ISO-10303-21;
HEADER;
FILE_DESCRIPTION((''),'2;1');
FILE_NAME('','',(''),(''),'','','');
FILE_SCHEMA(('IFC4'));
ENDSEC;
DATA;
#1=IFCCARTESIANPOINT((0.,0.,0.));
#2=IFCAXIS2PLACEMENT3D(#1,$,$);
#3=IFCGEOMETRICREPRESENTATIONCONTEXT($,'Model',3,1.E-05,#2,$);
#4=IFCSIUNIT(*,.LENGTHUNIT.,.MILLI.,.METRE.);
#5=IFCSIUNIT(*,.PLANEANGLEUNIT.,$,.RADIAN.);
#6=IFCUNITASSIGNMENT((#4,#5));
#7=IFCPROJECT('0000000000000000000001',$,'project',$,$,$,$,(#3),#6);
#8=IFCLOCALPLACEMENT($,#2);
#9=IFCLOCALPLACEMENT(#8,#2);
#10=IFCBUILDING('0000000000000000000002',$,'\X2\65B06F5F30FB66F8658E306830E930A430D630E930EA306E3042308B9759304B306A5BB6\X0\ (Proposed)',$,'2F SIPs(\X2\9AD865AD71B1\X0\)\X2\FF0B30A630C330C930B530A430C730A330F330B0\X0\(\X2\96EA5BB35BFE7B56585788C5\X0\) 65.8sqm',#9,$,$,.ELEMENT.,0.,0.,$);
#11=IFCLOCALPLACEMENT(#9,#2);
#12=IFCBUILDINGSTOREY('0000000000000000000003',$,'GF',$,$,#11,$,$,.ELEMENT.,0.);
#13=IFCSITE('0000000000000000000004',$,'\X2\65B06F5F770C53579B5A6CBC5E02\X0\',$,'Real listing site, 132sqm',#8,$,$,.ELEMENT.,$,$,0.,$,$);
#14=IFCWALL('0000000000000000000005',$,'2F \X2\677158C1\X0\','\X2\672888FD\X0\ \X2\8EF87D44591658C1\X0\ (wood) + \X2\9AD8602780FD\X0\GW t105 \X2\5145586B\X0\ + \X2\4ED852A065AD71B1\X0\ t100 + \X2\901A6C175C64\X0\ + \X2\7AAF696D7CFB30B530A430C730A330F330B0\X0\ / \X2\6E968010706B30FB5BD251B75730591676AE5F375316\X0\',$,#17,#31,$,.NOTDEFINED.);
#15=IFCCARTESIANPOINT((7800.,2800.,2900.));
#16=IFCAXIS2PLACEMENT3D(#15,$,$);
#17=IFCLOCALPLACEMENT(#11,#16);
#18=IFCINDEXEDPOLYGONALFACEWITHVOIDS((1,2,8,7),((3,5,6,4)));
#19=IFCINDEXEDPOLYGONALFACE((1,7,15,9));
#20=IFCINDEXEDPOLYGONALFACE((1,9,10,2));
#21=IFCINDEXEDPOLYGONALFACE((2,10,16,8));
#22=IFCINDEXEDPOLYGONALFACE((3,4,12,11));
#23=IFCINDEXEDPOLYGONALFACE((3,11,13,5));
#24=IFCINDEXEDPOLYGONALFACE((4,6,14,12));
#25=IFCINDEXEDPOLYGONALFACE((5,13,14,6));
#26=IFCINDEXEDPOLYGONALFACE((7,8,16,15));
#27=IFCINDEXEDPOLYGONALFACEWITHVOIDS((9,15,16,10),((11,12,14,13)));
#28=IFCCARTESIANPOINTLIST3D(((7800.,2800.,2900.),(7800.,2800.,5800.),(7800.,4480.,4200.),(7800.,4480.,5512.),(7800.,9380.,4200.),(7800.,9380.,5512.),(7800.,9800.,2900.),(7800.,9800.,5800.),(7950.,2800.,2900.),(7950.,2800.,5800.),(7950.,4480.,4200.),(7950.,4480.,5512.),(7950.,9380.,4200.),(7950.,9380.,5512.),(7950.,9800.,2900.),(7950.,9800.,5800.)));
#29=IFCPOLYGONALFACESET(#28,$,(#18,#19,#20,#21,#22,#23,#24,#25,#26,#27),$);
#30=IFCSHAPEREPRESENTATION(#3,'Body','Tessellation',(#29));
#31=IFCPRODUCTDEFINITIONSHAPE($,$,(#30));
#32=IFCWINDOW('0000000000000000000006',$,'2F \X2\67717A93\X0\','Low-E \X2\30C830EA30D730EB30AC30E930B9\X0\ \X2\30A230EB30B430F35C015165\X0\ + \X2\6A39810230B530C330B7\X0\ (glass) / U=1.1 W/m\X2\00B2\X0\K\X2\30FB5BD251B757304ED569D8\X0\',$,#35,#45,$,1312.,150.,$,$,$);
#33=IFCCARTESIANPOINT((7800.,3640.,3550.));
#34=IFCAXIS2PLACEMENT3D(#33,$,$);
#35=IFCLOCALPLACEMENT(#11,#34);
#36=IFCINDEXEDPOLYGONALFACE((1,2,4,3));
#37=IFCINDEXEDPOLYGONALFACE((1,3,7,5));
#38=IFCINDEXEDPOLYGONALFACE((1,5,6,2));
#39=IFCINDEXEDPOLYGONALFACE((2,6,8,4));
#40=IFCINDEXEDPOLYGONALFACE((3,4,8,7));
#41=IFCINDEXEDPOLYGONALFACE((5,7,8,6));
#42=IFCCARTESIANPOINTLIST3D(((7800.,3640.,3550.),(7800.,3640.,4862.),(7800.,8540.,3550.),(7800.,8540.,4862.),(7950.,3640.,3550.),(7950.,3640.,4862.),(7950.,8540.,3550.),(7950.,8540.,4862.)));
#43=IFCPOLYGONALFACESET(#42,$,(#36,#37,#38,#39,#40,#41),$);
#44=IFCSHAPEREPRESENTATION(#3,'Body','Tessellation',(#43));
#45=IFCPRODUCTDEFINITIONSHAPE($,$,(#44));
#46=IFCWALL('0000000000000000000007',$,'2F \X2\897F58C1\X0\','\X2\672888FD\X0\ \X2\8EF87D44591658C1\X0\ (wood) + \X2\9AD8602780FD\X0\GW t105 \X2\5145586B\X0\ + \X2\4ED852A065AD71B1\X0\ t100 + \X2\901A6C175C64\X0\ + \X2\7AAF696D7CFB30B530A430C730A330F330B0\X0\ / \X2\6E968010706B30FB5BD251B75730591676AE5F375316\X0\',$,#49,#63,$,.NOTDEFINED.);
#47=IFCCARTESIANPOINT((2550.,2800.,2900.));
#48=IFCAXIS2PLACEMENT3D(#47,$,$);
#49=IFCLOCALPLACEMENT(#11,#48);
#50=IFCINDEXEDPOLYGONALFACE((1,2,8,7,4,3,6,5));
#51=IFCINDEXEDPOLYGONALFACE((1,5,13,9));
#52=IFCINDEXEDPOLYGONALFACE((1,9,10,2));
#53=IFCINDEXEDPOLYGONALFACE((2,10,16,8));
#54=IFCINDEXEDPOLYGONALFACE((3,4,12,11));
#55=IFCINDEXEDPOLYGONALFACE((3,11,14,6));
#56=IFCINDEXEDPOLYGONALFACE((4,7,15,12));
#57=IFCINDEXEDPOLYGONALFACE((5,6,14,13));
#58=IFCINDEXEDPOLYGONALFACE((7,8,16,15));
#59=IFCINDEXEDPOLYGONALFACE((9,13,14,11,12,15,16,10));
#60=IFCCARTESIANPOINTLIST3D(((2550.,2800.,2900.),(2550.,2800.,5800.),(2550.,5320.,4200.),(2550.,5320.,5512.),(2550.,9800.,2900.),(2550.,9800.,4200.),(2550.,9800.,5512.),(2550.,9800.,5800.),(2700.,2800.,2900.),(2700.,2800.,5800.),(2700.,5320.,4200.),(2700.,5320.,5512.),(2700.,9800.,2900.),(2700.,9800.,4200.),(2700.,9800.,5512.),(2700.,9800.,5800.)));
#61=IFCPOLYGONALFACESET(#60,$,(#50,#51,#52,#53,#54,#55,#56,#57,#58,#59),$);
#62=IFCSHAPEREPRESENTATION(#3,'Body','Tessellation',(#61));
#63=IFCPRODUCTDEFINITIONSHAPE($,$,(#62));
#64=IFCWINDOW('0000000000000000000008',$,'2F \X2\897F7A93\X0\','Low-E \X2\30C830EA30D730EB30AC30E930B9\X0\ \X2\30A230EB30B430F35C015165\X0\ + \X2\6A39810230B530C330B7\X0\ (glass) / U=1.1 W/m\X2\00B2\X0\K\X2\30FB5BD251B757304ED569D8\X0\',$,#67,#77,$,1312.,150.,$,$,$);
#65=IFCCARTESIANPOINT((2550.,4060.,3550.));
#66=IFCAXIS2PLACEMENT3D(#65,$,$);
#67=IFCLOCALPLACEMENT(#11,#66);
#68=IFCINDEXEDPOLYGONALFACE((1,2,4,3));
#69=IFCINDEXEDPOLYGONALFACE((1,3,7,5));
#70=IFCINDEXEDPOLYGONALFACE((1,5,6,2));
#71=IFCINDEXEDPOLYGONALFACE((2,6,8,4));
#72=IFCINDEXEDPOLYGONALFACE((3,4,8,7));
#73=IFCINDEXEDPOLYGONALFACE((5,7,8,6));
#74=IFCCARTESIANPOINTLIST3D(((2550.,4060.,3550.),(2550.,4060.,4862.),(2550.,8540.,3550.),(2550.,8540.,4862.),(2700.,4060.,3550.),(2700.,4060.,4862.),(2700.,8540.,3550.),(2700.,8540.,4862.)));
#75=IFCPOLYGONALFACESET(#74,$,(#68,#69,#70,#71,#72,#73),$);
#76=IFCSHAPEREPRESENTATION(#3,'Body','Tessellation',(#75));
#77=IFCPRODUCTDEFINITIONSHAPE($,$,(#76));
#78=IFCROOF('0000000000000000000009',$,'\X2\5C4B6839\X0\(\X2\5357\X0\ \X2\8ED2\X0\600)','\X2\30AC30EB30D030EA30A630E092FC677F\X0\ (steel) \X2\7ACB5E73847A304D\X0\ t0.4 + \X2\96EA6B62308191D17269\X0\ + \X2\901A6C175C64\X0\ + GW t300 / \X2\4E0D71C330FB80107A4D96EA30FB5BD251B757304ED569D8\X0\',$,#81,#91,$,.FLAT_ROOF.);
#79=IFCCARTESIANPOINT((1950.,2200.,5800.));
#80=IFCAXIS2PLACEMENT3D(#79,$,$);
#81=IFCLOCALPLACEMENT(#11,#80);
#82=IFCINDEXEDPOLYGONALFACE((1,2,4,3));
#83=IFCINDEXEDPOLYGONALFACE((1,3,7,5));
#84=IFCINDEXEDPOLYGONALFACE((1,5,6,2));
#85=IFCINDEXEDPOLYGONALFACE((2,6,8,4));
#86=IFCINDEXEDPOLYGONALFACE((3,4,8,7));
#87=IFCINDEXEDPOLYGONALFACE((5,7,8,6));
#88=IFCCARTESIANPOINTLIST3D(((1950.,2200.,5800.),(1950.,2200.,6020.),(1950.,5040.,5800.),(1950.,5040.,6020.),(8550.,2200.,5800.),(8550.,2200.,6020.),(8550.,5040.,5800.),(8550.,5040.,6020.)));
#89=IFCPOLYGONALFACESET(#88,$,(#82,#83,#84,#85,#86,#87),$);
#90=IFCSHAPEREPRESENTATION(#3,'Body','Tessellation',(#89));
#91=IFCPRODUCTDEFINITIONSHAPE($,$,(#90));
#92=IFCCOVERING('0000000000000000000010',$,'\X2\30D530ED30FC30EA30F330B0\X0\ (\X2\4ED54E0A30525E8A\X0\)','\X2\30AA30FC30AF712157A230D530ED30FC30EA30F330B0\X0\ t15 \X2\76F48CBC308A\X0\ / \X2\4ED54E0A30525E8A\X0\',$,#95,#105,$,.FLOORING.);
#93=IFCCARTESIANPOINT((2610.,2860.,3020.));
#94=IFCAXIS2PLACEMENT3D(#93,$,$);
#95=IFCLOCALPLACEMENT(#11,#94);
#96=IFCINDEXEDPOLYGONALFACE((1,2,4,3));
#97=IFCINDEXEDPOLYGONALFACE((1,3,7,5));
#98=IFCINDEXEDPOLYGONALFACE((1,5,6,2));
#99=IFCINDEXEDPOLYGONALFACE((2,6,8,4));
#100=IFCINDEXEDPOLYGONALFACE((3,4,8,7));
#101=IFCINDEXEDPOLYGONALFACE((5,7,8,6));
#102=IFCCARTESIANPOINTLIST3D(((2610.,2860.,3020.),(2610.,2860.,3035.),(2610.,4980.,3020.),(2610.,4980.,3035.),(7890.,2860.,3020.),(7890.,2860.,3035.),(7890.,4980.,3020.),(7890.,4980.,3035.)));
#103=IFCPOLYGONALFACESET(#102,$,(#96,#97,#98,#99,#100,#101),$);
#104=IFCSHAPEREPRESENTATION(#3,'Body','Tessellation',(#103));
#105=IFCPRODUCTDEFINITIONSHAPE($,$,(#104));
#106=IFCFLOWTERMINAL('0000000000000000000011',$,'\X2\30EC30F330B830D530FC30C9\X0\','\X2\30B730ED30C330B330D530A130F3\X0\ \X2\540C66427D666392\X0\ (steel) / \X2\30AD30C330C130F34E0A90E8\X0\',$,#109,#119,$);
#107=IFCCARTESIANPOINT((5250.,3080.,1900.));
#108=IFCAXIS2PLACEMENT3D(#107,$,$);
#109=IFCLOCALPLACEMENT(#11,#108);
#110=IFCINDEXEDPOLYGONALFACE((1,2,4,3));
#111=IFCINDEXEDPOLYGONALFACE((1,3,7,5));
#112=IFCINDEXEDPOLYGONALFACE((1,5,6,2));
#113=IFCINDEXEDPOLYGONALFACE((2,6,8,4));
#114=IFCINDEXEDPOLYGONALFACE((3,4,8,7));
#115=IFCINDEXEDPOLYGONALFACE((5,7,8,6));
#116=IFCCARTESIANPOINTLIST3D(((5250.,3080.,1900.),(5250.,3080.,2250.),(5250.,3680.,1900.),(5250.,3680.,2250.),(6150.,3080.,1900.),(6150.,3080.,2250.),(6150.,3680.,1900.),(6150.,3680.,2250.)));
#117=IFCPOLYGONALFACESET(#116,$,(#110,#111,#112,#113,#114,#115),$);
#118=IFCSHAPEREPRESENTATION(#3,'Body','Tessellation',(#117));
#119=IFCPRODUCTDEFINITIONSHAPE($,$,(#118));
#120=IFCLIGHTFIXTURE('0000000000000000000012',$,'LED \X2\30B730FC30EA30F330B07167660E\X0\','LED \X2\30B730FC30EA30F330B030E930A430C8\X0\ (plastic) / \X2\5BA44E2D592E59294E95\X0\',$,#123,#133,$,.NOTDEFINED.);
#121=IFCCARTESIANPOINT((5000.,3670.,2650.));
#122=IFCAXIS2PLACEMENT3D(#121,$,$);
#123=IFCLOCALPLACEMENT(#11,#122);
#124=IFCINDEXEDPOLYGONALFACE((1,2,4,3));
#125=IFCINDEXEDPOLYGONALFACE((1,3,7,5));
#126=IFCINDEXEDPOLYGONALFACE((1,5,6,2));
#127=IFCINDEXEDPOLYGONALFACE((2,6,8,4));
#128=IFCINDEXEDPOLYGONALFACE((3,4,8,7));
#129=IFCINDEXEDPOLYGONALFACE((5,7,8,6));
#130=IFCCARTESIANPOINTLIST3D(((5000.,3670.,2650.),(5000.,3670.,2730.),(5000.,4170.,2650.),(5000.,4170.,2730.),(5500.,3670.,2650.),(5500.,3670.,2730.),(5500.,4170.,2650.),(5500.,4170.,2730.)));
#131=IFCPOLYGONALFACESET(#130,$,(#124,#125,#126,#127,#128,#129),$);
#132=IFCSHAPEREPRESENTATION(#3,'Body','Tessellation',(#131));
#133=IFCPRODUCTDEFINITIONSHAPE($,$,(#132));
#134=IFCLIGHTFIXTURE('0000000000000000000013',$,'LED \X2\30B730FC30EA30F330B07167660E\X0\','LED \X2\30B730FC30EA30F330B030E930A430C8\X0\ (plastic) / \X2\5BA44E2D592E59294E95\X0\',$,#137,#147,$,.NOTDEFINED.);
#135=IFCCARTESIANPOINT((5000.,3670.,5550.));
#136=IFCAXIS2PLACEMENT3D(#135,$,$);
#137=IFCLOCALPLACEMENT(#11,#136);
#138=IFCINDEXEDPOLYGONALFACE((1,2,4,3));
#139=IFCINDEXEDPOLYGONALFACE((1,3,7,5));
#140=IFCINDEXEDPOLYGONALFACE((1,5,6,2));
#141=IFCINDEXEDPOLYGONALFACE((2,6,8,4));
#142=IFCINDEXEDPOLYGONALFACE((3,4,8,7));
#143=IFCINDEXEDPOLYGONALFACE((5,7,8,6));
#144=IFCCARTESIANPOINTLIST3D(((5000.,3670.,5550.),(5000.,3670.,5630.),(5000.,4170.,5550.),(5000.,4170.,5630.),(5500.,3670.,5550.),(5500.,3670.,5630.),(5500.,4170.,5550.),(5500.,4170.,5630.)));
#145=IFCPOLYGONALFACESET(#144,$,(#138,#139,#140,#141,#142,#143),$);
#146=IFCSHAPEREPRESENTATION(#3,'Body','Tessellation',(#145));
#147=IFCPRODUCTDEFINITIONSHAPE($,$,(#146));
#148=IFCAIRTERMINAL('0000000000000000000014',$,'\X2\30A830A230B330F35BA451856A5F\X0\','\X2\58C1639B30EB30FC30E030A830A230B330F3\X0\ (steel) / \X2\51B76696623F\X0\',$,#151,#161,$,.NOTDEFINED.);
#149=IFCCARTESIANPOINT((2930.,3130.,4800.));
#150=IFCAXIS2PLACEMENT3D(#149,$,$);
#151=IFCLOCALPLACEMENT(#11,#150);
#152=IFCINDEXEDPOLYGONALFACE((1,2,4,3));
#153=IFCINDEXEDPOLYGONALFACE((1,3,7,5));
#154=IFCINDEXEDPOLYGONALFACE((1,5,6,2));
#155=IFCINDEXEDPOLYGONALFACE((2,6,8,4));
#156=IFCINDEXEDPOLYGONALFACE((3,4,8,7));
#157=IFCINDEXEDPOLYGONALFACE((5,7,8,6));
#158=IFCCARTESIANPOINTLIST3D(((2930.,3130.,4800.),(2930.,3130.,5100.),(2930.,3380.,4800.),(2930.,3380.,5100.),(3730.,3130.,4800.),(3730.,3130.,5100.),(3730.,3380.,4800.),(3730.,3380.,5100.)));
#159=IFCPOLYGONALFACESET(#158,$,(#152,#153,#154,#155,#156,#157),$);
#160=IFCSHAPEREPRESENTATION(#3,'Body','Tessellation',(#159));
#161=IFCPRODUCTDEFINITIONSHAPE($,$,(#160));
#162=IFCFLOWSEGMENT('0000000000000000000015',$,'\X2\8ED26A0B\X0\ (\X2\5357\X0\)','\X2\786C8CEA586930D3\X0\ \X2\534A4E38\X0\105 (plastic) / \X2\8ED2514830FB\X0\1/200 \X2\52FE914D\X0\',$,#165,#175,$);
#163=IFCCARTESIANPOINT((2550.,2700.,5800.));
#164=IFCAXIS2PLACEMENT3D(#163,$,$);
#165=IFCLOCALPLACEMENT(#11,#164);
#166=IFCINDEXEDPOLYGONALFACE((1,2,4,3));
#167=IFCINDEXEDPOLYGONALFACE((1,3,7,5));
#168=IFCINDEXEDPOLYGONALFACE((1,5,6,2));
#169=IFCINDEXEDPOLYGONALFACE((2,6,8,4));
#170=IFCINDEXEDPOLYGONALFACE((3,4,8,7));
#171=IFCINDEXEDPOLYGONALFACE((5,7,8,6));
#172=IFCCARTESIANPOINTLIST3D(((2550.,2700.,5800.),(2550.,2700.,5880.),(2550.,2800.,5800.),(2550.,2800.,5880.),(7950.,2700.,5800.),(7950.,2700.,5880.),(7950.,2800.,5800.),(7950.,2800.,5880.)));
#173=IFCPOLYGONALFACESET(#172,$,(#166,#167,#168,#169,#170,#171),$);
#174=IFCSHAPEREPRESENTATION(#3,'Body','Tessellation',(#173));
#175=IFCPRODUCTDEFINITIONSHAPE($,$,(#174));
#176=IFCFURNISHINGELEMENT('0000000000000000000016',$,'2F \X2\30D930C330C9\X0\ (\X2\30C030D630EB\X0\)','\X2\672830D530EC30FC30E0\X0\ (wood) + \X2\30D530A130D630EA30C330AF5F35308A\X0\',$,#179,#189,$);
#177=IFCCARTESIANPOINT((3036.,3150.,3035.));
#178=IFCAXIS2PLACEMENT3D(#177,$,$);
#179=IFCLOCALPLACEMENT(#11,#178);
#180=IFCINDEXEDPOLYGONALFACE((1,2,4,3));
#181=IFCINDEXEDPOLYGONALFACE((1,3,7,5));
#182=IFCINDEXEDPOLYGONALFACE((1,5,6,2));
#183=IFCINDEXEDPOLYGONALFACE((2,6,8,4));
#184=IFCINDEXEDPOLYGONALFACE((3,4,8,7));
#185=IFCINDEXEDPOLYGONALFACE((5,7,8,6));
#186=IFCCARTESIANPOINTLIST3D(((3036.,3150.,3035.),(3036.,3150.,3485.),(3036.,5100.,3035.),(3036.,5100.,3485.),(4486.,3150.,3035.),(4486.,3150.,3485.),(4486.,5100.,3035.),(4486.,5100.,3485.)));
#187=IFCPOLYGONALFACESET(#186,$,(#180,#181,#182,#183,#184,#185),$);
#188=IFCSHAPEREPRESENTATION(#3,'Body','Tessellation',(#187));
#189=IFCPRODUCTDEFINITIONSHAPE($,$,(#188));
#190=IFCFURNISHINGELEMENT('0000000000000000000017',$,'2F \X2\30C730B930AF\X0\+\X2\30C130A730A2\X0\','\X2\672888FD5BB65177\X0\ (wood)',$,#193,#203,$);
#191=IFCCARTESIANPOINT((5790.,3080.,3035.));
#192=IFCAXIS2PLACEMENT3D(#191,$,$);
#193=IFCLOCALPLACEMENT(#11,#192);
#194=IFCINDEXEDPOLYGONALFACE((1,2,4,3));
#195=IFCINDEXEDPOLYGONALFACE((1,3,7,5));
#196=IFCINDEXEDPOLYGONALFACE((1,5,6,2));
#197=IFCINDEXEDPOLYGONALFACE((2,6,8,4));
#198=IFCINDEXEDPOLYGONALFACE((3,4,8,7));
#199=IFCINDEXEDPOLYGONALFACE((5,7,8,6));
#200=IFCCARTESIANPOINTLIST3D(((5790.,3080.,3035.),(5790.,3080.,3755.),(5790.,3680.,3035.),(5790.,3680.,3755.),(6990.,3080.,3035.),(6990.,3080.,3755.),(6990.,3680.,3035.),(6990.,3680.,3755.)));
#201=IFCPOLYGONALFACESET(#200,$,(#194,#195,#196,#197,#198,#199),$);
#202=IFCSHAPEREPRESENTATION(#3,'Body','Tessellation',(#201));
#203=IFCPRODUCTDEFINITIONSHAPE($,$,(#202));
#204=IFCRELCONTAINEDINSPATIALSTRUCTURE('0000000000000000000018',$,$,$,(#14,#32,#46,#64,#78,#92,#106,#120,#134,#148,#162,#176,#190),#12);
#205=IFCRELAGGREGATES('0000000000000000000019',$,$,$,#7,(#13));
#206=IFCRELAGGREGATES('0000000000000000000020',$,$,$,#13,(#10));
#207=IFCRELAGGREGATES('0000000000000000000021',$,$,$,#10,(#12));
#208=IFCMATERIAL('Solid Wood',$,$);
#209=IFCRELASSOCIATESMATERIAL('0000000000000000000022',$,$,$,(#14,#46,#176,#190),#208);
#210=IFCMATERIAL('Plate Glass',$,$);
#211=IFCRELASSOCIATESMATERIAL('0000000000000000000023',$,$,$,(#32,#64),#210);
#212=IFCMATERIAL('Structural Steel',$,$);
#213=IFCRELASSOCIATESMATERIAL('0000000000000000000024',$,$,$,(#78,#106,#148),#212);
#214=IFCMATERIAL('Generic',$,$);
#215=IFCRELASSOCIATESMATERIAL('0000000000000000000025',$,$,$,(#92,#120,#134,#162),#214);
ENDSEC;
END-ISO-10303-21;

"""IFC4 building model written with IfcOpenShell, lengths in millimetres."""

from ifc_helpers import new_model, si_unit, frame, frame_2d, origin, place, context, project, spatial, rectangle, extrude, material, element, fill, save


model = new_model("IFC4")

# Units and contexts
model_context = context("Model", 3, precision=1e-05, world=origin())
ifc_project = project(units=[si_unit("LENGTHUNIT", "METRE", prefix="MILLI"), si_unit("PLANEANGLEUNIT", "RADIAN")], contexts=[model_context])

# Site, building, storey
site_placement = place(None, origin())
site = spatial("IfcSite", under=ifc_project, at=site_placement, Name="新潟県南魚沼市", ObjectType="Real listing site, 132sqm", CompositionType="ELEMENT", RefElevation=0.0)
building_placement = place(site_placement, origin())
building = spatial("IfcBuilding", under=site, at=building_placement, Name="新潟・書斎とライブラリのある静かな家 (Proposed)", ObjectType="2F SIPs(高断熱)＋ウッドサイディング(雪害対策塗装) 65.8sqm", CompositionType="ELEMENT", ElevationOfRefHeight=0.0, ElevationOfTerrain=0.0)
storey_placement = place(building_placement, origin())
storey = spatial("IfcBuildingStorey", under=building, at=storey_placement, Name="GF", CompositionType="ELEMENT", Elevation=0.0)

# Shared definitions
ifc_material_1 = material(Name="Solid Wood")

# Shared definitions
ifc_material_2 = material(Name="Plate Glass")

# Walls, openings, windows
wall_1_placement = place(storey_placement, frame((7800.0, 2800.0, 2900.0)))
wall_1 = element("IfcWall", 1, at=wall_1_placement, inside=storey, material=ifc_material_1, Name="2F 東壁", Description="木製 軸組外壁 (wood) + 高性能GW t105 充填 + 付加断熱 t100 + 通気層 + 窯業系サイディング / 準耐火・寒冷地外皮強化", PredefinedType="NOTDEFINED", context=model_context, shape_type="SweptSolid", body=[
    extrude(rectangle(XDim=150.0, YDim=7000.0, at=frame_2d((75.0, 3500.0))), frame((7800.0, 2800.0, 2900.0)), (0.0, 0.0, 1.0), 2900.0),
])
opening_1_placement = place(storey_placement, frame((7800.0, 3640.0, 3550.0)))
opening_1 = element("IfcOpeningElement", 2, at=opening_1_placement, cuts=wall_1, PredefinedType="NOTDEFINED", context=model_context, shape_type="SweptSolid", body=[
    extrude(rectangle(XDim=150.0, YDim=4900.0, at=frame_2d((75.0, 2450.0))), frame((7800.0, 3640.0, 3550.0)), (0.0, 0.0, 1.0), 1312.0),
])
window_1_placement = place(storey_placement, frame((7800.0, 3640.0, 3550.0)))
window_1 = element("IfcWindow", 3, at=window_1_placement, inside=storey, material=ifc_material_2, Name="2F 東窓", Description="Low-E トリプルガラス アルゴン封入 + 樹脂サッシ (glass) / U=1.1 W/m²K・寒冷地仕様", OverallHeight=1312.0, OverallWidth=150.0, context=model_context, shape_type="SweptSolid", body=[
    extrude(rectangle(XDim=150.0, YDim=4900.0, at=frame_2d((75.0, 2450.0))), frame((7800.0, 3640.0, 3550.0)), (0.0, 0.0, 1.0), 1312.0),
])
fill(opening_1, window_1)
wall_2_placement = place(storey_placement, frame((2550.0, 2800.0, 2900.0)))
wall_2 = element("IfcWall", 4, at=wall_2_placement, inside=storey, material=ifc_material_1, Name="2F 西壁", Description="木製 軸組外壁 (wood) + 高性能GW t105 充填 + 付加断熱 t100 + 通気層 + 窯業系サイディング / 準耐火・寒冷地外皮強化", PredefinedType="NOTDEFINED", context=model_context, shape_type="SweptSolid", body=[
    extrude(rectangle(XDim=150.0, YDim=7000.0, at=frame_2d((75.0, 3500.0))), frame((2550.0, 2800.0, 2900.0)), (0.0, 0.0, 1.0), 2900.0),
])
opening_2_placement = place(storey_placement, frame((2550.0, 4060.0, 3550.0)))
opening_2 = element("IfcOpeningElement", 5, at=opening_2_placement, cuts=wall_2, PredefinedType="NOTDEFINED", context=model_context, shape_type="SweptSolid", body=[
    extrude(rectangle(XDim=150.0, YDim=4480.0, at=frame_2d((75.0, 2240.0))), frame((2550.0, 4060.0, 3550.0)), (0.0, 0.0, 1.0), 1312.0),
])
window_2_placement = place(storey_placement, frame((2550.0, 4060.0, 3550.0)))
window_2 = element("IfcWindow", 6, at=window_2_placement, inside=storey, material=ifc_material_2, Name="2F 西窓", Description="Low-E トリプルガラス アルゴン封入 + 樹脂サッシ (glass) / U=1.1 W/m²K・寒冷地仕様", OverallHeight=1312.0, OverallWidth=150.0, context=model_context, shape_type="SweptSolid", body=[
    extrude(rectangle(XDim=150.0, YDim=4480.0, at=frame_2d((75.0, 2240.0))), frame((2550.0, 4060.0, 3550.0)), (0.0, 0.0, 1.0), 1312.0),
])
fill(opening_2, window_2)

# Roof
ifc_material_3 = material(Name="Structural Steel")
for number, where, name in (
    (7, (1950.0, 2200.0, 5800.0), "屋根(南 軒600)"),
):
    element("IfcRoof", number, at=place(storey_placement, frame(where)), inside=storey, material=ifc_material_3, Name=name, Description="ガルバリウム鋼板 (steel) 立平葺き t0.4 + 雪止め金物 + 通気層 + GW t300 / 不燃・耐積雪・寒冷地仕様", PredefinedType="FLAT_ROOF", context=model_context, shape_type="SweptSolid", body=[
        extrude(rectangle(XDim=6600.0, YDim=2840.0, at=frame_2d((3300.0, 1420.0))), frame((1950.0, 2200.0, 5800.0)), (0.0, 0.0, 1.0), 220.0),
    ])

# Covering
ifc_material_4 = material(Name="Generic")
covering_placement = place(storey_placement, frame((2610.0, 2860.0, 3020.0)))
element("IfcCovering", 8, at=covering_placement, inside=storey, material=ifc_material_4, Name="フローリング (仕上げ床)", Description="オーク無垢フローリング t15 直貼り / 仕上げ床", PredefinedType="FLOORING", context=model_context, shape_type="SweptSolid", body=[
    extrude(rectangle(XDim=5280.0, YDim=2120.0, at=frame_2d((2640.0, 1060.0))), frame((2610.0, 2860.0, 3020.0)), (0.0, 0.0, 1.0), 15.0),
])

# Flow terminal
flow_terminal_placement = place(storey_placement, frame((5250.0, 3080.0, 1900.0)))
element("IfcFlowTerminal", 9, at=flow_terminal_placement, inside=storey, material=ifc_material_3, Name="レンジフード", Description="シロッコファン 同時給排 (steel) / キッチン上部", context=model_context, shape_type="SweptSolid", body=[
    extrude(rectangle(XDim=900.0, YDim=600.0, at=frame_2d((450.0, 300.0))), frame((5250.0, 3080.0, 1900.0)), (0.0, 0.0, 1.0), 350.0),
])

# Light fixtures
light_fixture_1_placement = place(storey_placement, frame((5000.0, 3670.0, 2650.0)))
element("IfcLightFixture", 10, at=light_fixture_1_placement, inside=storey, material=ifc_material_4, Name="LED シーリング照明", Description="LED シーリングライト (plastic) / 室中央天井", PredefinedType="NOTDEFINED", context=model_context, shape_type="SweptSolid", body=[
    extrude(rectangle(XDim=500.0, YDim=500.0, at=frame_2d((250.0, 250.0))), frame((5000.0, 3670.0, 2650.0)), (0.0, 0.0, 1.0), 80.0),
])
light_fixture_2_placement = place(storey_placement, frame((5000.0, 3670.0, 5550.0)))
element("IfcLightFixture", 11, at=light_fixture_2_placement, inside=storey, material=ifc_material_4, Name="LED シーリング照明", Description="LED シーリングライト (plastic) / 室中央天井", PredefinedType="NOTDEFINED", context=model_context, shape_type="SweptSolid", body=[
    extrude(rectangle(XDim=500.0, YDim=500.0, at=frame_2d((250.0, 250.0))), frame((5000.0, 3670.0, 5550.0)), (0.0, 0.0, 1.0), 80.0),
])

# Air terminal
air_terminal_placement = place(storey_placement, frame((2930.0, 3130.0, 4800.0)))
element("IfcAirTerminal", 12, at=air_terminal_placement, inside=storey, material=ifc_material_3, Name="エアコン室内機", Description="壁掛ルームエアコン (steel) / 冷暖房", PredefinedType="NOTDEFINED", context=model_context, shape_type="SweptSolid", body=[
    extrude(rectangle(XDim=800.0, YDim=250.0, at=frame_2d((400.0, 125.0))), frame((2930.0, 3130.0, 4800.0)), (0.0, 0.0, 1.0), 300.0),
])

# Flow segment
flow_segment_placement = place(storey_placement, frame((2550.0, 2700.0, 5800.0)))
element("IfcFlowSegment", 13, at=flow_segment_placement, inside=storey, material=ifc_material_4, Name="軒樋 (南)", Description="硬質塩ビ 半丸105 (plastic) / 軒先・1/200 勾配", context=model_context, shape_type="SweptSolid", body=[
    extrude(rectangle(XDim=5400.0, YDim=100.0, at=frame_2d((2700.0, 50.0))), frame((2550.0, 2700.0, 5800.0)), (0.0, 0.0, 1.0), 80.0),
])

# Furnishing elements
furnishing_1_placement = place(storey_placement, frame((3036.0, 3150.0, 3035.0)))
element("IfcFurnishingElement", 14, at=furnishing_1_placement, inside=storey, material=ifc_material_1, Name="2F ベッド (ダブル)", Description="木フレーム (wood) + ファブリック張り", context=model_context, shape_type="SweptSolid", body=[
    extrude(rectangle(XDim=1450.0, YDim=1950.0, at=frame_2d((725.0, 975.0))), frame((3036.0, 3150.0, 3035.0)), (0.0, 0.0, 1.0), 450.0),
])
furnishing_2_placement = place(storey_placement, frame((5790.0, 3080.0, 3035.0)))
element("IfcFurnishingElement", 15, at=furnishing_2_placement, inside=storey, material=ifc_material_1, Name="2F デスク+チェア", Description="木製家具 (wood)", context=model_context, shape_type="SweptSolid", body=[
    extrude(rectangle(XDim=1200.0, YDim=600.0, at=frame_2d((600.0, 300.0))), frame((5790.0, 3080.0, 3035.0)), (0.0, 0.0, 1.0), 720.0),
])

save(model, "model.ifc")
